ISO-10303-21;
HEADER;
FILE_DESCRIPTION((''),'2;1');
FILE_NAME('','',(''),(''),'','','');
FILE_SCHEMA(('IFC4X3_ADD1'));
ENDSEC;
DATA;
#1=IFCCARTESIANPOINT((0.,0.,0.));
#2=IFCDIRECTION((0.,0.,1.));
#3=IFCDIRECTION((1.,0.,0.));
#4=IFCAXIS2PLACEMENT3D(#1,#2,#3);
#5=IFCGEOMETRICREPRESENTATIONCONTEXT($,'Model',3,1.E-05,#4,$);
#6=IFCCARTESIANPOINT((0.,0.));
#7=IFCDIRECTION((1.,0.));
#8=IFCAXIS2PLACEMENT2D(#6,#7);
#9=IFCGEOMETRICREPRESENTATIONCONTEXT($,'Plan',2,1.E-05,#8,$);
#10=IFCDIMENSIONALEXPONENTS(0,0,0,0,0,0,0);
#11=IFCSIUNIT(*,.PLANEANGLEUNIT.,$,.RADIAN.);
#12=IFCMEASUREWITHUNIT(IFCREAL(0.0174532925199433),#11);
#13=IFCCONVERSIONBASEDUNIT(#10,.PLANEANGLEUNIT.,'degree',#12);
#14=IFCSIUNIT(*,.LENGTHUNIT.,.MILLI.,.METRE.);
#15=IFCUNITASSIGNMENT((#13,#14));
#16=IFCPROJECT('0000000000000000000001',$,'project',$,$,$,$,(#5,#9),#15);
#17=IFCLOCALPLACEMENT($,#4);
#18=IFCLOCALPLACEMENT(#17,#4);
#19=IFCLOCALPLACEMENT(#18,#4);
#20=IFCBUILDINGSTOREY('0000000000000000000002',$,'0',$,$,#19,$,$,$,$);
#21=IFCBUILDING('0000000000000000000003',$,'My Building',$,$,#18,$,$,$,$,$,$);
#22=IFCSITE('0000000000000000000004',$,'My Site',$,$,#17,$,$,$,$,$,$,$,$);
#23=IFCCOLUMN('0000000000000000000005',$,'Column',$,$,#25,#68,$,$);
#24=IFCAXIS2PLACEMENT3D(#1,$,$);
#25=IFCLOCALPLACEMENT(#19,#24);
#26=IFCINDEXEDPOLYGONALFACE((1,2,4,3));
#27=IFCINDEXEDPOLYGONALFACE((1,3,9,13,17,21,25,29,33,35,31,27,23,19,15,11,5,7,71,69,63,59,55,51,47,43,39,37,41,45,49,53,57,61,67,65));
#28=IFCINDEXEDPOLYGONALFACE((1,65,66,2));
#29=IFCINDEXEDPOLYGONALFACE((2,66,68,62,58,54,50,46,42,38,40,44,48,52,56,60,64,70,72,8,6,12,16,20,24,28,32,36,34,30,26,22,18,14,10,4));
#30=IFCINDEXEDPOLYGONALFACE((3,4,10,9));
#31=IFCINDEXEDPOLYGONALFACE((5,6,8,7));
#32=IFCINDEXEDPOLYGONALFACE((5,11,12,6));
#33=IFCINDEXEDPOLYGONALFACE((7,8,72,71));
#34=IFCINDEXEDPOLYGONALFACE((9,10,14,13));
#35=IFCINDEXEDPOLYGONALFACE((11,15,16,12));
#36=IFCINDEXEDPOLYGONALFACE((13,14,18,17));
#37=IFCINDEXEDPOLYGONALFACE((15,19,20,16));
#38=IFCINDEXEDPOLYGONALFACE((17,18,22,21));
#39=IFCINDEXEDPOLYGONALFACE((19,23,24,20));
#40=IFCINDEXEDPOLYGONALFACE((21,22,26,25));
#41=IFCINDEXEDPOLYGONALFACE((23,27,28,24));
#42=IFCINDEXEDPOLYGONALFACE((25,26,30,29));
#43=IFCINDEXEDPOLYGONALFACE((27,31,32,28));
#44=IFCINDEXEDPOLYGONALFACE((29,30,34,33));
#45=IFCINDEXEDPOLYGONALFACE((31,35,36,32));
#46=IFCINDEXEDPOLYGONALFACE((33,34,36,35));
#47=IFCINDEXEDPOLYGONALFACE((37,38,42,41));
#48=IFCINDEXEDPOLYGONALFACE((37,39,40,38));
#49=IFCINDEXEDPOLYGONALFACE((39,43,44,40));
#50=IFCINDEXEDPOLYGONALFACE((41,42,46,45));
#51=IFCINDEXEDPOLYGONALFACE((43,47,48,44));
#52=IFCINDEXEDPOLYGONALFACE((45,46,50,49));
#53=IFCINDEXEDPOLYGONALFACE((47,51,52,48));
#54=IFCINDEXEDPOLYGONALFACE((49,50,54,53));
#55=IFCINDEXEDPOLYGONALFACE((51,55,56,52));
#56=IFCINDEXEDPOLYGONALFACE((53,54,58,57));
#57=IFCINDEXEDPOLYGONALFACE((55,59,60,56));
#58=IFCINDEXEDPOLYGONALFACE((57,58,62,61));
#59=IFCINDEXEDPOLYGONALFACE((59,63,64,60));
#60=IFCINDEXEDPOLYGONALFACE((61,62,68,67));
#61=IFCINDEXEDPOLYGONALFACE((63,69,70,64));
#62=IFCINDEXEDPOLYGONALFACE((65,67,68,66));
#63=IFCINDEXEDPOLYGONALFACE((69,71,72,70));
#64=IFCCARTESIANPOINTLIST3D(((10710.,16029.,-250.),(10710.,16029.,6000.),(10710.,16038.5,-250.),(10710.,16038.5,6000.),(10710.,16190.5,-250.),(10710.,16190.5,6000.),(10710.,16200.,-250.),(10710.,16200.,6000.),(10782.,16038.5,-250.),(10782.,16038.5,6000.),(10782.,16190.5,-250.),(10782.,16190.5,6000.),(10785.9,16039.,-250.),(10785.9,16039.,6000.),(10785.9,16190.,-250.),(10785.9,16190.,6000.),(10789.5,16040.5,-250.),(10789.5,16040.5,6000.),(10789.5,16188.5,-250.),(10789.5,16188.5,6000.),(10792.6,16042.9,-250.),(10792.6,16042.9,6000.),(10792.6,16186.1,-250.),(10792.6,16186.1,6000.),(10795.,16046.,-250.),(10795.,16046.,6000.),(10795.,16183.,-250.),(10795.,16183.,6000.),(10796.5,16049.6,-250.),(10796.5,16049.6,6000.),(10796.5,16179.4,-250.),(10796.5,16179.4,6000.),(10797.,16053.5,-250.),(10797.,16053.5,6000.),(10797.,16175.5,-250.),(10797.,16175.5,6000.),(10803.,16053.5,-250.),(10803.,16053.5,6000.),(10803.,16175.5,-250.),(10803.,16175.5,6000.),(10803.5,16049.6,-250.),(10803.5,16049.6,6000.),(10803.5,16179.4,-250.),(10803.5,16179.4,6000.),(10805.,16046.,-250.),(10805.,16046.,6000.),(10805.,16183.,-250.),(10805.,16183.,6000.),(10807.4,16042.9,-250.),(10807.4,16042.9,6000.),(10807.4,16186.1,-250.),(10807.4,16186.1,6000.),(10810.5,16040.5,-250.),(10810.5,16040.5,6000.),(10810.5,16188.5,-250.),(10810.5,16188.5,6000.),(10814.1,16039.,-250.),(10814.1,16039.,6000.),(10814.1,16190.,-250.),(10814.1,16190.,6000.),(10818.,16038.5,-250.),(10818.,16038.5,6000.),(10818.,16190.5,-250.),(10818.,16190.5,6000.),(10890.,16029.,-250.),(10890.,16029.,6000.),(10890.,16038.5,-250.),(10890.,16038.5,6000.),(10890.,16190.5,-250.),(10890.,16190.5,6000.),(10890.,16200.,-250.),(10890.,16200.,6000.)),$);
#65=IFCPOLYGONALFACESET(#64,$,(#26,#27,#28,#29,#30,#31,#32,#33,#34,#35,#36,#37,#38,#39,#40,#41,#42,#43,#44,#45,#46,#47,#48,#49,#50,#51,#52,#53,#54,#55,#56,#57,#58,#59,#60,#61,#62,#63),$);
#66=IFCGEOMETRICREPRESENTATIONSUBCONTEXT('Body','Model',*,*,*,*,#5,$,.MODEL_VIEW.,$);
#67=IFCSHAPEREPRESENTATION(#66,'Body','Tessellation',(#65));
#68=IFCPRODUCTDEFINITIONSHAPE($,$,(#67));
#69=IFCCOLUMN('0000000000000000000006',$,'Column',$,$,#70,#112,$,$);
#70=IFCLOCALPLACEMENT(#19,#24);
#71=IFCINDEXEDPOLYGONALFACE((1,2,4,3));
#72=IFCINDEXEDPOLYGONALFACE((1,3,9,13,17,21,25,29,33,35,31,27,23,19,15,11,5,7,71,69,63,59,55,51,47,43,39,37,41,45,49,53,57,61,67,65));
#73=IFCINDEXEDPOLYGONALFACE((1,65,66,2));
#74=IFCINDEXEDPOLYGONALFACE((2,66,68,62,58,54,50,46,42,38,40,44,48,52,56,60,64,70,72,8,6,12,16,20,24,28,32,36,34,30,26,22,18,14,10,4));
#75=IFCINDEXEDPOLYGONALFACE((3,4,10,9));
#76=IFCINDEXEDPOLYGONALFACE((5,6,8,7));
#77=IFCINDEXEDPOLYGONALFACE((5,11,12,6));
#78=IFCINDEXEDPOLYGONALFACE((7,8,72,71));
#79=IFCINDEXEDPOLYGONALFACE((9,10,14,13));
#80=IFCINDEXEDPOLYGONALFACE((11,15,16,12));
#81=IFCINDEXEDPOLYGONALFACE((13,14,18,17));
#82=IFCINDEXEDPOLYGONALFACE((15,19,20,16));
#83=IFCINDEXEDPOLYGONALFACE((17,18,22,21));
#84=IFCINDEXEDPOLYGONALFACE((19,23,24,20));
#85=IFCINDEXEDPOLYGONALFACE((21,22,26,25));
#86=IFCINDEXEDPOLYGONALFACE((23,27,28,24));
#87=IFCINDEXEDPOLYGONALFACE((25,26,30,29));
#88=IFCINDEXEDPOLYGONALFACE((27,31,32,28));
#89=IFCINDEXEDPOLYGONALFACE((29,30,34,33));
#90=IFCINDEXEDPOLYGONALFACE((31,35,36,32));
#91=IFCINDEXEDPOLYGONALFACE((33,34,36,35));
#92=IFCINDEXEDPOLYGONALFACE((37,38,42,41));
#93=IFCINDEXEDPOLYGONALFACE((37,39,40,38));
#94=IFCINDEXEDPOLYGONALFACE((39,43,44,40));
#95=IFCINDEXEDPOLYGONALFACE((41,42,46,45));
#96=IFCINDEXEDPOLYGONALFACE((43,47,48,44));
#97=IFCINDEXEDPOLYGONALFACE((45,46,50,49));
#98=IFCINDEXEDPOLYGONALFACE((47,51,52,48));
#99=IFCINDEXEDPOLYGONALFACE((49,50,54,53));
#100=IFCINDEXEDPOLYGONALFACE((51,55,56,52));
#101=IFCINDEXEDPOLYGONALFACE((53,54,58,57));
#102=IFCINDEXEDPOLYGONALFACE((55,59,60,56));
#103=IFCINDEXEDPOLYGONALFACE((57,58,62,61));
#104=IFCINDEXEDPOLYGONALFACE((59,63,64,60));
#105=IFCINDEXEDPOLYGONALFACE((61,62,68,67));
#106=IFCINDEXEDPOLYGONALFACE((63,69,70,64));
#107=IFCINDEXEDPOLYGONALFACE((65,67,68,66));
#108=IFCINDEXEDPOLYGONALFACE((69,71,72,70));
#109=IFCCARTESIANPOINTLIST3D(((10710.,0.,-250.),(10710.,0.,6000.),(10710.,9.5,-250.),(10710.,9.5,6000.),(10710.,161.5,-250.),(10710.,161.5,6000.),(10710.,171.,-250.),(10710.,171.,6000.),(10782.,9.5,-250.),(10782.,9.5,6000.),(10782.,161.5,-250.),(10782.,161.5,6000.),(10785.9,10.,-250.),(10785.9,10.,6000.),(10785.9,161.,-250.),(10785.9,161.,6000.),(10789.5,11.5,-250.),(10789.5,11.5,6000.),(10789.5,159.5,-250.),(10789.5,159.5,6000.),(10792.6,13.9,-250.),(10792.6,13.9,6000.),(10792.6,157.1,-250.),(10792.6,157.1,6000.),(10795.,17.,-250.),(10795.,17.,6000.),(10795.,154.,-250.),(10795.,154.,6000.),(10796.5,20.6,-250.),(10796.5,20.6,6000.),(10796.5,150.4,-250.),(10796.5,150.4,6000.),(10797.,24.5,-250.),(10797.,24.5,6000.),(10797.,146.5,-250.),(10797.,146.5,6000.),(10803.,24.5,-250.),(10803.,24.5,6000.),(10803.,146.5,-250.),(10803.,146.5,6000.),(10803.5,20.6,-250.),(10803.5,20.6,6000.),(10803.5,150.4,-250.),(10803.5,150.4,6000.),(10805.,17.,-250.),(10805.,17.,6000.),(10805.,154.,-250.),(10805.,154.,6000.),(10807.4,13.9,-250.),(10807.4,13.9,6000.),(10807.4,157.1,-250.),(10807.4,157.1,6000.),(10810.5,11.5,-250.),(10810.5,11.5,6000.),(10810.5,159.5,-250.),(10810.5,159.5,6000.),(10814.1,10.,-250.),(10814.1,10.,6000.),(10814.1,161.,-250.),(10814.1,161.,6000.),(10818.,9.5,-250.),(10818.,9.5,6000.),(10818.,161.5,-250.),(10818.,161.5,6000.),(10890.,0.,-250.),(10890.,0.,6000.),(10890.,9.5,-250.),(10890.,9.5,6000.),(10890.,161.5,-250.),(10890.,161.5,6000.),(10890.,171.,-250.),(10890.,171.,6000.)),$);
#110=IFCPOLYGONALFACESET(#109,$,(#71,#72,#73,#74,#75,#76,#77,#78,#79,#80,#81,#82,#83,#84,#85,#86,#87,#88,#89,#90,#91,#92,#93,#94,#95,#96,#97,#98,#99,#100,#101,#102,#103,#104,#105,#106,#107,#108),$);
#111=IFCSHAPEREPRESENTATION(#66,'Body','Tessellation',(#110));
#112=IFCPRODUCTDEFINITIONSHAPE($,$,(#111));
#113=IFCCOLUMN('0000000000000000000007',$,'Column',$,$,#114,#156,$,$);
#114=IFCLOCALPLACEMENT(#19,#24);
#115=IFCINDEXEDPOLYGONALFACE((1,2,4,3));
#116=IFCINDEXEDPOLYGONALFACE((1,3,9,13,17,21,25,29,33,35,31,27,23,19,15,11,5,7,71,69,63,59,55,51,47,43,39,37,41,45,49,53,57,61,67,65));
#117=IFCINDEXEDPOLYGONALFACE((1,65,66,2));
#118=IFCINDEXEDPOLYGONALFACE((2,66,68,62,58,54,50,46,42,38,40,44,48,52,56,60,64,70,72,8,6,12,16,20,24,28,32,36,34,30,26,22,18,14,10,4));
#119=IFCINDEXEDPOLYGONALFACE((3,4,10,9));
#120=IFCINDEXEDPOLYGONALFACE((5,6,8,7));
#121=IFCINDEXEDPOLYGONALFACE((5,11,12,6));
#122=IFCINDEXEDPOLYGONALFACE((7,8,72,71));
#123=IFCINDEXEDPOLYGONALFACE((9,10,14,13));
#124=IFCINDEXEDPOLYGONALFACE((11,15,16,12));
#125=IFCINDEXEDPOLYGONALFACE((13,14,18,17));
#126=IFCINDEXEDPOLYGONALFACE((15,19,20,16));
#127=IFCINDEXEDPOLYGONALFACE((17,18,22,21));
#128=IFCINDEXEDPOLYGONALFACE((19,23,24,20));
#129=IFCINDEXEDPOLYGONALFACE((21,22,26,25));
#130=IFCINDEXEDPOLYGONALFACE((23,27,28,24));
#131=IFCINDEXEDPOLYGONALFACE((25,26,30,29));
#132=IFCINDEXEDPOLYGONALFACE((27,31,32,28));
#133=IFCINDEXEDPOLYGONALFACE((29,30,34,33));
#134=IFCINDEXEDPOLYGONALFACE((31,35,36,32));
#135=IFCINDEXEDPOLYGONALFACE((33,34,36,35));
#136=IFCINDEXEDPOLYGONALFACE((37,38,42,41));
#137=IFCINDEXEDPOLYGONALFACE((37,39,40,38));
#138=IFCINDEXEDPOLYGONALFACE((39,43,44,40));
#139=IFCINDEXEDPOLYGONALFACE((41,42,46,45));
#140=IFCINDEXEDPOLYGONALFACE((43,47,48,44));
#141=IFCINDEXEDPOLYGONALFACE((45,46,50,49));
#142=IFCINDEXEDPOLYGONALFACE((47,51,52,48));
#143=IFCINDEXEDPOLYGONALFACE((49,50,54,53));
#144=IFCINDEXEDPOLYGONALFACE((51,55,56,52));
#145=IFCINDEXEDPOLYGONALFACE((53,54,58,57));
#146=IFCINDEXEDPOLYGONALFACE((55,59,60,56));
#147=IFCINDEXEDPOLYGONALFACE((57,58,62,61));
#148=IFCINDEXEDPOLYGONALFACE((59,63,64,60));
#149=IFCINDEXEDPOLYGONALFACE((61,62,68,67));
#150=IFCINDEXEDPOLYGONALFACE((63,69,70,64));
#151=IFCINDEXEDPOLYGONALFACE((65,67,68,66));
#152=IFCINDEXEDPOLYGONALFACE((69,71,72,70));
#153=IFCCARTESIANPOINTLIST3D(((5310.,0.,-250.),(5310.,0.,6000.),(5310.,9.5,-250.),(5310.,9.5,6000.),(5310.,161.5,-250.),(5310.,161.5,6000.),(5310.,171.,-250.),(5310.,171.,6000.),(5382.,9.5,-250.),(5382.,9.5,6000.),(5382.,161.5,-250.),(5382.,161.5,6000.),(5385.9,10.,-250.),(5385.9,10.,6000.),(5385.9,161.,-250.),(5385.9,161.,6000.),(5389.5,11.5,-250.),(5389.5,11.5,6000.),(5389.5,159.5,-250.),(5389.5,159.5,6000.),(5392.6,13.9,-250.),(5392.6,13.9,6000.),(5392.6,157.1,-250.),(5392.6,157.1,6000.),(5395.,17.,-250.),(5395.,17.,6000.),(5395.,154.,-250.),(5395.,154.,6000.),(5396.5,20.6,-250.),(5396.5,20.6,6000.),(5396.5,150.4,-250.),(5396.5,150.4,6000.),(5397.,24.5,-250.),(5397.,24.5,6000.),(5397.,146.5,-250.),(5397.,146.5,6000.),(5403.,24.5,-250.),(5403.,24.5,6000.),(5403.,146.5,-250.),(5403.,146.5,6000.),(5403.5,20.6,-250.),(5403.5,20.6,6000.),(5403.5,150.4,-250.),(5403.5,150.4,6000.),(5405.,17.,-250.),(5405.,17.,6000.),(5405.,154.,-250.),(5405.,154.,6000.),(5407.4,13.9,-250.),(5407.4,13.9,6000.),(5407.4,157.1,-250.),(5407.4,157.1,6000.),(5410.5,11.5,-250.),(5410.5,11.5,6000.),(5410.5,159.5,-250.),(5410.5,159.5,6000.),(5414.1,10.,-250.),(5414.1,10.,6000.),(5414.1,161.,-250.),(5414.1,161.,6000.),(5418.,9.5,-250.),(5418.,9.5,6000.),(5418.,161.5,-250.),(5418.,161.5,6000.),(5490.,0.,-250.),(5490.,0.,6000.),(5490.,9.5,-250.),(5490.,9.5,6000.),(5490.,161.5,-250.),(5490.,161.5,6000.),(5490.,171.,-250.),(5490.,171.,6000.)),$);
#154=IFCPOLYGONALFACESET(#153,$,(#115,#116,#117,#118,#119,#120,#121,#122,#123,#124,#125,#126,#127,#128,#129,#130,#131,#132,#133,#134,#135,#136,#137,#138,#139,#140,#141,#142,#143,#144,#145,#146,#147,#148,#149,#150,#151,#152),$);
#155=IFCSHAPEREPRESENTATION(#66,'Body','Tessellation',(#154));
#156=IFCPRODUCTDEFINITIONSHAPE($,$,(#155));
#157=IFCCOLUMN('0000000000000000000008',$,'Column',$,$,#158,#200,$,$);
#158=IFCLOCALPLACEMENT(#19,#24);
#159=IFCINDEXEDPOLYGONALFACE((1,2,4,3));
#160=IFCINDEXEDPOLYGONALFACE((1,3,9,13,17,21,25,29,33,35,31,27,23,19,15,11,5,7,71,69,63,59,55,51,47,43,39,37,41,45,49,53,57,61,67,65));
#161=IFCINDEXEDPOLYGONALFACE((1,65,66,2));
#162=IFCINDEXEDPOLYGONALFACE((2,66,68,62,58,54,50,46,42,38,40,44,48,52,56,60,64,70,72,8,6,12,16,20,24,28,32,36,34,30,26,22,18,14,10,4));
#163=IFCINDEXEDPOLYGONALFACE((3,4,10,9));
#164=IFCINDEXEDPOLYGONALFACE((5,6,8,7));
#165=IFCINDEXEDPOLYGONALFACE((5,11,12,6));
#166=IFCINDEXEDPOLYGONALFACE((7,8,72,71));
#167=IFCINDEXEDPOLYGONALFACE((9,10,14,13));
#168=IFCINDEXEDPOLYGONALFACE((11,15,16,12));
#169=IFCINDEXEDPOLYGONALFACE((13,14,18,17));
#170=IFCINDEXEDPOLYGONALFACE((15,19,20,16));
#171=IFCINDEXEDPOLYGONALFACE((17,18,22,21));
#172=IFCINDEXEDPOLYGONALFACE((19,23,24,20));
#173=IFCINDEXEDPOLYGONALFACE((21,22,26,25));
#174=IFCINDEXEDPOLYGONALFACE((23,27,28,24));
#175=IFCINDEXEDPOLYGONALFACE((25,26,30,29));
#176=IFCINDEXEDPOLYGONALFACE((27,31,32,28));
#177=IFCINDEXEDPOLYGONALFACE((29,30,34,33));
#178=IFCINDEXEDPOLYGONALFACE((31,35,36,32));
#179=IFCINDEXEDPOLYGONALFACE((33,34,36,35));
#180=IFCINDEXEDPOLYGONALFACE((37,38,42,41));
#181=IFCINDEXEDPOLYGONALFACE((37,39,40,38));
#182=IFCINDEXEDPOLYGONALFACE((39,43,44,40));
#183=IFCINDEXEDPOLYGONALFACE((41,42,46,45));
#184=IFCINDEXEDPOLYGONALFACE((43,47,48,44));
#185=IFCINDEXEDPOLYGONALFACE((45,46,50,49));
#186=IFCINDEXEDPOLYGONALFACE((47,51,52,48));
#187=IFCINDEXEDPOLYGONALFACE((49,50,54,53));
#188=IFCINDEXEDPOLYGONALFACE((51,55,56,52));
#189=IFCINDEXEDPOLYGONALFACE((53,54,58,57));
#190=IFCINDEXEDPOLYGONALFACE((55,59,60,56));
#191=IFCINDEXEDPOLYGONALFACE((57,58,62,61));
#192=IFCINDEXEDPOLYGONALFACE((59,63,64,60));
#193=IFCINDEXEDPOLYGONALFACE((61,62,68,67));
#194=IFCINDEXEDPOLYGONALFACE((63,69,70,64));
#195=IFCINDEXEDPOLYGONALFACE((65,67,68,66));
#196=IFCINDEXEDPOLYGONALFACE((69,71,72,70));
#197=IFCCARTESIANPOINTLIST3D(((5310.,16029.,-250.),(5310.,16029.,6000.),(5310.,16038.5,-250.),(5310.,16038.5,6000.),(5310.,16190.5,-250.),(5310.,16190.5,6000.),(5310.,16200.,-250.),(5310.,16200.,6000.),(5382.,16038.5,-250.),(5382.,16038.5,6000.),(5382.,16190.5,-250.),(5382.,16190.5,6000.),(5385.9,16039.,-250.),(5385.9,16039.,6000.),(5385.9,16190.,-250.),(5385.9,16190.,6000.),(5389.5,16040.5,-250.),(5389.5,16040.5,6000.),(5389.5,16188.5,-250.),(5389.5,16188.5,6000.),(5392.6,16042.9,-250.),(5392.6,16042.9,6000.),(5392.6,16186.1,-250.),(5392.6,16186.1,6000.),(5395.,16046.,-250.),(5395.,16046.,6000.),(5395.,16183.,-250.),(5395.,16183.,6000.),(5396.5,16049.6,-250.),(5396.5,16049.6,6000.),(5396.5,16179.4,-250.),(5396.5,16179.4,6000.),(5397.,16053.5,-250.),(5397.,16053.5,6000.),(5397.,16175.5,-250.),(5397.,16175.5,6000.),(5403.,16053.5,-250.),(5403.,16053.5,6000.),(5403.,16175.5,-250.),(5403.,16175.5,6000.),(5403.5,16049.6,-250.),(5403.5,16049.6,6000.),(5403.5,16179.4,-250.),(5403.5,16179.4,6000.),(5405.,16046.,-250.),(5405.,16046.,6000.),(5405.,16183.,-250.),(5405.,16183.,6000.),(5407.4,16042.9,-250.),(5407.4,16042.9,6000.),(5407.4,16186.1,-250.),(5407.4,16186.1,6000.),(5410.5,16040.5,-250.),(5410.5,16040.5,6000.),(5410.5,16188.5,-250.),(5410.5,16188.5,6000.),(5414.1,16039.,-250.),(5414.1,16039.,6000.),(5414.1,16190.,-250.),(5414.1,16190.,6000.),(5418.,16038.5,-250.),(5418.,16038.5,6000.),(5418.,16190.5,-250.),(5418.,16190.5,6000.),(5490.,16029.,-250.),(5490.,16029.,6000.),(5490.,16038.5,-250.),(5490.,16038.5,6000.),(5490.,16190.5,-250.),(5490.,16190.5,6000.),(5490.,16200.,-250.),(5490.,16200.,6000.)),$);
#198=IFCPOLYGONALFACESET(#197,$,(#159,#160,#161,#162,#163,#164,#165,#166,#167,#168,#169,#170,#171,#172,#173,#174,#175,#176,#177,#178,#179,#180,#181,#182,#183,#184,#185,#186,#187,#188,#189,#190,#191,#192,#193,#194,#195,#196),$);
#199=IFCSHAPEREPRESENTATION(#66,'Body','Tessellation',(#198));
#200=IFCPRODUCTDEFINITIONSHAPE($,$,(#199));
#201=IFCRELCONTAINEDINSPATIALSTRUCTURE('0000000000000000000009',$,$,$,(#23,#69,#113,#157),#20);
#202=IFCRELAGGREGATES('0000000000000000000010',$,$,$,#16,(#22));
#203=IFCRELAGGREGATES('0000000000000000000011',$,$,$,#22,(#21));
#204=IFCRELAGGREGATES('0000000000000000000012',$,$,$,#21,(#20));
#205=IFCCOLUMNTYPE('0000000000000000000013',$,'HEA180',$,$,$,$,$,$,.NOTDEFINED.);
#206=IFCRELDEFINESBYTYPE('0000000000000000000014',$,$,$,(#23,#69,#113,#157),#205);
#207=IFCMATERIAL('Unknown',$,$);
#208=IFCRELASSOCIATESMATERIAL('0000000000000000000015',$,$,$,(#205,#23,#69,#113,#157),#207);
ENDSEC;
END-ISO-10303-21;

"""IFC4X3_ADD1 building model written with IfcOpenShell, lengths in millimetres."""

from ifc_helpers import new_model, entity, si_unit, converted_unit, frame, origin_with_axes, origin_2d_with_axis, place, context, subcontext, project, spatial, i_section, extrude, material, material_profile, profile_set, profile_usage, type_object, element, save


model = new_model("IFC4X3_ADD1")

# Units and contexts
model_context = context("Model", 3, precision=1e-05, world=origin_with_axes())
plan_context = context("Plan", 2, precision=1e-05, world=origin_2d_with_axis())
body_context = subcontext(model_context, "Body", "Model", "MODEL_VIEW")
ifc_project = project(units=[converted_unit("PLANEANGLEUNIT", "degree", entity("IfcReal", 0.0174532925199433), si_unit("PLANEANGLEUNIT", "RADIAN"), dimensions=[0, 0, 0, 0, 0, 0, 0]), si_unit("LENGTHUNIT", "METRE", prefix="MILLI")], contexts=[model_context, plan_context])

# Site, building, storey
site_placement = place(None, origin_with_axes())
site = spatial("IfcSite", under=ifc_project, at=site_placement, Name="My Site")
building_placement = place(site_placement, origin_with_axes())
building = spatial("IfcBuilding", under=site, at=building_placement, Name="My Building")
storey_placement = place(building_placement, origin_with_axes())
storey = spatial("IfcBuildingStorey", under=building, at=storey_placement, Name="0")

# Columns
ifc_material = material(Name="Unknown")
ifc_material_profile_1 = material_profile(ifc_material, i_section(OverallWidth=180.0, OverallDepth=171.0, WebThickness=6.0, FlangeThickness=9.5, FilletRadius=15.0))
ifc_profile_set_1 = profile_set([ifc_material_profile_1])
column_type = type_object("IfcColumnType", Name="HEA180", PredefinedType="NOTDEFINED", material=ifc_profile_set_1)
ifc_profile_usage_1 = profile_usage(ifc_profile_set_1, cardinal=8)
column_1_placement = place(storey_placement, frame((10800.0, 16200.0, -250.0), z_axis=(0.0, 0.0, 1.0), x_axis=(1.0, 0.0, 0.0)))
element("IfcColumn", 1, at=column_1_placement, inside=storey, type_object=column_type, material=ifc_profile_usage_1, Name="Column", context=body_context, shape_type="SweptSolid", body=[
    extrude(i_section(OverallWidth=180.0, OverallDepth=171.0, WebThickness=6.0, FlangeThickness=9.5, FilletRadius=15.0), frame((0.0, -85.5, 0.0), z_axis=(0.0, 0.0, 1.0), x_axis=(1.0, 0.0, 0.0)), (0.0, 0.0, 1.0), 6250.0),
])
ifc_profile_usage_2 = profile_usage(ifc_profile_set_1, cardinal=2)
column_2_placement = place(storey_placement, frame((10800.0, 0.0, -250.0), z_axis=(0.0, 0.0, 1.0), x_axis=(1.0, 0.0, 0.0)))
element("IfcColumn", 2, at=column_2_placement, inside=storey, type_object=column_type, material=ifc_profile_usage_2, Name="Column", context=body_context, shape_type="SweptSolid", body=[
    extrude(i_section(OverallWidth=180.0, OverallDepth=171.0, WebThickness=6.0, FlangeThickness=9.5, FilletRadius=15.0), frame((0.0, 85.5, 0.0), z_axis=(0.0, 0.0, 1.0), x_axis=(1.0, 0.0, 0.0)), (0.0, 0.0, 1.0), 6250.0),
])
ifc_profile_usage_3 = profile_usage(ifc_profile_set_1, cardinal=2)
column_3_placement = place(storey_placement, frame((5400.0, 0.0, -250.0), z_axis=(0.0, 0.0, 1.0), x_axis=(1.0, 0.0, 0.0)))
element("IfcColumn", 3, at=column_3_placement, inside=storey, type_object=column_type, material=ifc_profile_usage_3, Name="Column", context=body_context, shape_type="SweptSolid", body=[
    extrude(i_section(OverallWidth=180.0, OverallDepth=171.0, WebThickness=6.0, FlangeThickness=9.5, FilletRadius=15.0), frame((0.0, 85.5, 0.0), z_axis=(0.0, 0.0, 1.0), x_axis=(1.0, 0.0, 0.0)), (0.0, 0.0, 1.0), 6250.0),
])
ifc_profile_usage_4 = profile_usage(ifc_profile_set_1, cardinal=8)
column_4_placement = place(storey_placement, frame((5400.0, 16200.0, -250.0), z_axis=(0.0, 0.0, 1.0), x_axis=(1.0, 0.0, 0.0)))
element("IfcColumn", 4, at=column_4_placement, inside=storey, type_object=column_type, material=ifc_profile_usage_4, Name="Column", context=body_context, shape_type="SweptSolid", body=[
    extrude(i_section(OverallWidth=180.0, OverallDepth=171.0, WebThickness=6.0, FlangeThickness=9.5, FilletRadius=15.0), frame((0.0, -85.5, 0.0), z_axis=(0.0, 0.0, 1.0), x_axis=(1.0, 0.0, 0.0)), (0.0, 0.0, 1.0), 6250.0),
])

save(model, "model.ifc")
